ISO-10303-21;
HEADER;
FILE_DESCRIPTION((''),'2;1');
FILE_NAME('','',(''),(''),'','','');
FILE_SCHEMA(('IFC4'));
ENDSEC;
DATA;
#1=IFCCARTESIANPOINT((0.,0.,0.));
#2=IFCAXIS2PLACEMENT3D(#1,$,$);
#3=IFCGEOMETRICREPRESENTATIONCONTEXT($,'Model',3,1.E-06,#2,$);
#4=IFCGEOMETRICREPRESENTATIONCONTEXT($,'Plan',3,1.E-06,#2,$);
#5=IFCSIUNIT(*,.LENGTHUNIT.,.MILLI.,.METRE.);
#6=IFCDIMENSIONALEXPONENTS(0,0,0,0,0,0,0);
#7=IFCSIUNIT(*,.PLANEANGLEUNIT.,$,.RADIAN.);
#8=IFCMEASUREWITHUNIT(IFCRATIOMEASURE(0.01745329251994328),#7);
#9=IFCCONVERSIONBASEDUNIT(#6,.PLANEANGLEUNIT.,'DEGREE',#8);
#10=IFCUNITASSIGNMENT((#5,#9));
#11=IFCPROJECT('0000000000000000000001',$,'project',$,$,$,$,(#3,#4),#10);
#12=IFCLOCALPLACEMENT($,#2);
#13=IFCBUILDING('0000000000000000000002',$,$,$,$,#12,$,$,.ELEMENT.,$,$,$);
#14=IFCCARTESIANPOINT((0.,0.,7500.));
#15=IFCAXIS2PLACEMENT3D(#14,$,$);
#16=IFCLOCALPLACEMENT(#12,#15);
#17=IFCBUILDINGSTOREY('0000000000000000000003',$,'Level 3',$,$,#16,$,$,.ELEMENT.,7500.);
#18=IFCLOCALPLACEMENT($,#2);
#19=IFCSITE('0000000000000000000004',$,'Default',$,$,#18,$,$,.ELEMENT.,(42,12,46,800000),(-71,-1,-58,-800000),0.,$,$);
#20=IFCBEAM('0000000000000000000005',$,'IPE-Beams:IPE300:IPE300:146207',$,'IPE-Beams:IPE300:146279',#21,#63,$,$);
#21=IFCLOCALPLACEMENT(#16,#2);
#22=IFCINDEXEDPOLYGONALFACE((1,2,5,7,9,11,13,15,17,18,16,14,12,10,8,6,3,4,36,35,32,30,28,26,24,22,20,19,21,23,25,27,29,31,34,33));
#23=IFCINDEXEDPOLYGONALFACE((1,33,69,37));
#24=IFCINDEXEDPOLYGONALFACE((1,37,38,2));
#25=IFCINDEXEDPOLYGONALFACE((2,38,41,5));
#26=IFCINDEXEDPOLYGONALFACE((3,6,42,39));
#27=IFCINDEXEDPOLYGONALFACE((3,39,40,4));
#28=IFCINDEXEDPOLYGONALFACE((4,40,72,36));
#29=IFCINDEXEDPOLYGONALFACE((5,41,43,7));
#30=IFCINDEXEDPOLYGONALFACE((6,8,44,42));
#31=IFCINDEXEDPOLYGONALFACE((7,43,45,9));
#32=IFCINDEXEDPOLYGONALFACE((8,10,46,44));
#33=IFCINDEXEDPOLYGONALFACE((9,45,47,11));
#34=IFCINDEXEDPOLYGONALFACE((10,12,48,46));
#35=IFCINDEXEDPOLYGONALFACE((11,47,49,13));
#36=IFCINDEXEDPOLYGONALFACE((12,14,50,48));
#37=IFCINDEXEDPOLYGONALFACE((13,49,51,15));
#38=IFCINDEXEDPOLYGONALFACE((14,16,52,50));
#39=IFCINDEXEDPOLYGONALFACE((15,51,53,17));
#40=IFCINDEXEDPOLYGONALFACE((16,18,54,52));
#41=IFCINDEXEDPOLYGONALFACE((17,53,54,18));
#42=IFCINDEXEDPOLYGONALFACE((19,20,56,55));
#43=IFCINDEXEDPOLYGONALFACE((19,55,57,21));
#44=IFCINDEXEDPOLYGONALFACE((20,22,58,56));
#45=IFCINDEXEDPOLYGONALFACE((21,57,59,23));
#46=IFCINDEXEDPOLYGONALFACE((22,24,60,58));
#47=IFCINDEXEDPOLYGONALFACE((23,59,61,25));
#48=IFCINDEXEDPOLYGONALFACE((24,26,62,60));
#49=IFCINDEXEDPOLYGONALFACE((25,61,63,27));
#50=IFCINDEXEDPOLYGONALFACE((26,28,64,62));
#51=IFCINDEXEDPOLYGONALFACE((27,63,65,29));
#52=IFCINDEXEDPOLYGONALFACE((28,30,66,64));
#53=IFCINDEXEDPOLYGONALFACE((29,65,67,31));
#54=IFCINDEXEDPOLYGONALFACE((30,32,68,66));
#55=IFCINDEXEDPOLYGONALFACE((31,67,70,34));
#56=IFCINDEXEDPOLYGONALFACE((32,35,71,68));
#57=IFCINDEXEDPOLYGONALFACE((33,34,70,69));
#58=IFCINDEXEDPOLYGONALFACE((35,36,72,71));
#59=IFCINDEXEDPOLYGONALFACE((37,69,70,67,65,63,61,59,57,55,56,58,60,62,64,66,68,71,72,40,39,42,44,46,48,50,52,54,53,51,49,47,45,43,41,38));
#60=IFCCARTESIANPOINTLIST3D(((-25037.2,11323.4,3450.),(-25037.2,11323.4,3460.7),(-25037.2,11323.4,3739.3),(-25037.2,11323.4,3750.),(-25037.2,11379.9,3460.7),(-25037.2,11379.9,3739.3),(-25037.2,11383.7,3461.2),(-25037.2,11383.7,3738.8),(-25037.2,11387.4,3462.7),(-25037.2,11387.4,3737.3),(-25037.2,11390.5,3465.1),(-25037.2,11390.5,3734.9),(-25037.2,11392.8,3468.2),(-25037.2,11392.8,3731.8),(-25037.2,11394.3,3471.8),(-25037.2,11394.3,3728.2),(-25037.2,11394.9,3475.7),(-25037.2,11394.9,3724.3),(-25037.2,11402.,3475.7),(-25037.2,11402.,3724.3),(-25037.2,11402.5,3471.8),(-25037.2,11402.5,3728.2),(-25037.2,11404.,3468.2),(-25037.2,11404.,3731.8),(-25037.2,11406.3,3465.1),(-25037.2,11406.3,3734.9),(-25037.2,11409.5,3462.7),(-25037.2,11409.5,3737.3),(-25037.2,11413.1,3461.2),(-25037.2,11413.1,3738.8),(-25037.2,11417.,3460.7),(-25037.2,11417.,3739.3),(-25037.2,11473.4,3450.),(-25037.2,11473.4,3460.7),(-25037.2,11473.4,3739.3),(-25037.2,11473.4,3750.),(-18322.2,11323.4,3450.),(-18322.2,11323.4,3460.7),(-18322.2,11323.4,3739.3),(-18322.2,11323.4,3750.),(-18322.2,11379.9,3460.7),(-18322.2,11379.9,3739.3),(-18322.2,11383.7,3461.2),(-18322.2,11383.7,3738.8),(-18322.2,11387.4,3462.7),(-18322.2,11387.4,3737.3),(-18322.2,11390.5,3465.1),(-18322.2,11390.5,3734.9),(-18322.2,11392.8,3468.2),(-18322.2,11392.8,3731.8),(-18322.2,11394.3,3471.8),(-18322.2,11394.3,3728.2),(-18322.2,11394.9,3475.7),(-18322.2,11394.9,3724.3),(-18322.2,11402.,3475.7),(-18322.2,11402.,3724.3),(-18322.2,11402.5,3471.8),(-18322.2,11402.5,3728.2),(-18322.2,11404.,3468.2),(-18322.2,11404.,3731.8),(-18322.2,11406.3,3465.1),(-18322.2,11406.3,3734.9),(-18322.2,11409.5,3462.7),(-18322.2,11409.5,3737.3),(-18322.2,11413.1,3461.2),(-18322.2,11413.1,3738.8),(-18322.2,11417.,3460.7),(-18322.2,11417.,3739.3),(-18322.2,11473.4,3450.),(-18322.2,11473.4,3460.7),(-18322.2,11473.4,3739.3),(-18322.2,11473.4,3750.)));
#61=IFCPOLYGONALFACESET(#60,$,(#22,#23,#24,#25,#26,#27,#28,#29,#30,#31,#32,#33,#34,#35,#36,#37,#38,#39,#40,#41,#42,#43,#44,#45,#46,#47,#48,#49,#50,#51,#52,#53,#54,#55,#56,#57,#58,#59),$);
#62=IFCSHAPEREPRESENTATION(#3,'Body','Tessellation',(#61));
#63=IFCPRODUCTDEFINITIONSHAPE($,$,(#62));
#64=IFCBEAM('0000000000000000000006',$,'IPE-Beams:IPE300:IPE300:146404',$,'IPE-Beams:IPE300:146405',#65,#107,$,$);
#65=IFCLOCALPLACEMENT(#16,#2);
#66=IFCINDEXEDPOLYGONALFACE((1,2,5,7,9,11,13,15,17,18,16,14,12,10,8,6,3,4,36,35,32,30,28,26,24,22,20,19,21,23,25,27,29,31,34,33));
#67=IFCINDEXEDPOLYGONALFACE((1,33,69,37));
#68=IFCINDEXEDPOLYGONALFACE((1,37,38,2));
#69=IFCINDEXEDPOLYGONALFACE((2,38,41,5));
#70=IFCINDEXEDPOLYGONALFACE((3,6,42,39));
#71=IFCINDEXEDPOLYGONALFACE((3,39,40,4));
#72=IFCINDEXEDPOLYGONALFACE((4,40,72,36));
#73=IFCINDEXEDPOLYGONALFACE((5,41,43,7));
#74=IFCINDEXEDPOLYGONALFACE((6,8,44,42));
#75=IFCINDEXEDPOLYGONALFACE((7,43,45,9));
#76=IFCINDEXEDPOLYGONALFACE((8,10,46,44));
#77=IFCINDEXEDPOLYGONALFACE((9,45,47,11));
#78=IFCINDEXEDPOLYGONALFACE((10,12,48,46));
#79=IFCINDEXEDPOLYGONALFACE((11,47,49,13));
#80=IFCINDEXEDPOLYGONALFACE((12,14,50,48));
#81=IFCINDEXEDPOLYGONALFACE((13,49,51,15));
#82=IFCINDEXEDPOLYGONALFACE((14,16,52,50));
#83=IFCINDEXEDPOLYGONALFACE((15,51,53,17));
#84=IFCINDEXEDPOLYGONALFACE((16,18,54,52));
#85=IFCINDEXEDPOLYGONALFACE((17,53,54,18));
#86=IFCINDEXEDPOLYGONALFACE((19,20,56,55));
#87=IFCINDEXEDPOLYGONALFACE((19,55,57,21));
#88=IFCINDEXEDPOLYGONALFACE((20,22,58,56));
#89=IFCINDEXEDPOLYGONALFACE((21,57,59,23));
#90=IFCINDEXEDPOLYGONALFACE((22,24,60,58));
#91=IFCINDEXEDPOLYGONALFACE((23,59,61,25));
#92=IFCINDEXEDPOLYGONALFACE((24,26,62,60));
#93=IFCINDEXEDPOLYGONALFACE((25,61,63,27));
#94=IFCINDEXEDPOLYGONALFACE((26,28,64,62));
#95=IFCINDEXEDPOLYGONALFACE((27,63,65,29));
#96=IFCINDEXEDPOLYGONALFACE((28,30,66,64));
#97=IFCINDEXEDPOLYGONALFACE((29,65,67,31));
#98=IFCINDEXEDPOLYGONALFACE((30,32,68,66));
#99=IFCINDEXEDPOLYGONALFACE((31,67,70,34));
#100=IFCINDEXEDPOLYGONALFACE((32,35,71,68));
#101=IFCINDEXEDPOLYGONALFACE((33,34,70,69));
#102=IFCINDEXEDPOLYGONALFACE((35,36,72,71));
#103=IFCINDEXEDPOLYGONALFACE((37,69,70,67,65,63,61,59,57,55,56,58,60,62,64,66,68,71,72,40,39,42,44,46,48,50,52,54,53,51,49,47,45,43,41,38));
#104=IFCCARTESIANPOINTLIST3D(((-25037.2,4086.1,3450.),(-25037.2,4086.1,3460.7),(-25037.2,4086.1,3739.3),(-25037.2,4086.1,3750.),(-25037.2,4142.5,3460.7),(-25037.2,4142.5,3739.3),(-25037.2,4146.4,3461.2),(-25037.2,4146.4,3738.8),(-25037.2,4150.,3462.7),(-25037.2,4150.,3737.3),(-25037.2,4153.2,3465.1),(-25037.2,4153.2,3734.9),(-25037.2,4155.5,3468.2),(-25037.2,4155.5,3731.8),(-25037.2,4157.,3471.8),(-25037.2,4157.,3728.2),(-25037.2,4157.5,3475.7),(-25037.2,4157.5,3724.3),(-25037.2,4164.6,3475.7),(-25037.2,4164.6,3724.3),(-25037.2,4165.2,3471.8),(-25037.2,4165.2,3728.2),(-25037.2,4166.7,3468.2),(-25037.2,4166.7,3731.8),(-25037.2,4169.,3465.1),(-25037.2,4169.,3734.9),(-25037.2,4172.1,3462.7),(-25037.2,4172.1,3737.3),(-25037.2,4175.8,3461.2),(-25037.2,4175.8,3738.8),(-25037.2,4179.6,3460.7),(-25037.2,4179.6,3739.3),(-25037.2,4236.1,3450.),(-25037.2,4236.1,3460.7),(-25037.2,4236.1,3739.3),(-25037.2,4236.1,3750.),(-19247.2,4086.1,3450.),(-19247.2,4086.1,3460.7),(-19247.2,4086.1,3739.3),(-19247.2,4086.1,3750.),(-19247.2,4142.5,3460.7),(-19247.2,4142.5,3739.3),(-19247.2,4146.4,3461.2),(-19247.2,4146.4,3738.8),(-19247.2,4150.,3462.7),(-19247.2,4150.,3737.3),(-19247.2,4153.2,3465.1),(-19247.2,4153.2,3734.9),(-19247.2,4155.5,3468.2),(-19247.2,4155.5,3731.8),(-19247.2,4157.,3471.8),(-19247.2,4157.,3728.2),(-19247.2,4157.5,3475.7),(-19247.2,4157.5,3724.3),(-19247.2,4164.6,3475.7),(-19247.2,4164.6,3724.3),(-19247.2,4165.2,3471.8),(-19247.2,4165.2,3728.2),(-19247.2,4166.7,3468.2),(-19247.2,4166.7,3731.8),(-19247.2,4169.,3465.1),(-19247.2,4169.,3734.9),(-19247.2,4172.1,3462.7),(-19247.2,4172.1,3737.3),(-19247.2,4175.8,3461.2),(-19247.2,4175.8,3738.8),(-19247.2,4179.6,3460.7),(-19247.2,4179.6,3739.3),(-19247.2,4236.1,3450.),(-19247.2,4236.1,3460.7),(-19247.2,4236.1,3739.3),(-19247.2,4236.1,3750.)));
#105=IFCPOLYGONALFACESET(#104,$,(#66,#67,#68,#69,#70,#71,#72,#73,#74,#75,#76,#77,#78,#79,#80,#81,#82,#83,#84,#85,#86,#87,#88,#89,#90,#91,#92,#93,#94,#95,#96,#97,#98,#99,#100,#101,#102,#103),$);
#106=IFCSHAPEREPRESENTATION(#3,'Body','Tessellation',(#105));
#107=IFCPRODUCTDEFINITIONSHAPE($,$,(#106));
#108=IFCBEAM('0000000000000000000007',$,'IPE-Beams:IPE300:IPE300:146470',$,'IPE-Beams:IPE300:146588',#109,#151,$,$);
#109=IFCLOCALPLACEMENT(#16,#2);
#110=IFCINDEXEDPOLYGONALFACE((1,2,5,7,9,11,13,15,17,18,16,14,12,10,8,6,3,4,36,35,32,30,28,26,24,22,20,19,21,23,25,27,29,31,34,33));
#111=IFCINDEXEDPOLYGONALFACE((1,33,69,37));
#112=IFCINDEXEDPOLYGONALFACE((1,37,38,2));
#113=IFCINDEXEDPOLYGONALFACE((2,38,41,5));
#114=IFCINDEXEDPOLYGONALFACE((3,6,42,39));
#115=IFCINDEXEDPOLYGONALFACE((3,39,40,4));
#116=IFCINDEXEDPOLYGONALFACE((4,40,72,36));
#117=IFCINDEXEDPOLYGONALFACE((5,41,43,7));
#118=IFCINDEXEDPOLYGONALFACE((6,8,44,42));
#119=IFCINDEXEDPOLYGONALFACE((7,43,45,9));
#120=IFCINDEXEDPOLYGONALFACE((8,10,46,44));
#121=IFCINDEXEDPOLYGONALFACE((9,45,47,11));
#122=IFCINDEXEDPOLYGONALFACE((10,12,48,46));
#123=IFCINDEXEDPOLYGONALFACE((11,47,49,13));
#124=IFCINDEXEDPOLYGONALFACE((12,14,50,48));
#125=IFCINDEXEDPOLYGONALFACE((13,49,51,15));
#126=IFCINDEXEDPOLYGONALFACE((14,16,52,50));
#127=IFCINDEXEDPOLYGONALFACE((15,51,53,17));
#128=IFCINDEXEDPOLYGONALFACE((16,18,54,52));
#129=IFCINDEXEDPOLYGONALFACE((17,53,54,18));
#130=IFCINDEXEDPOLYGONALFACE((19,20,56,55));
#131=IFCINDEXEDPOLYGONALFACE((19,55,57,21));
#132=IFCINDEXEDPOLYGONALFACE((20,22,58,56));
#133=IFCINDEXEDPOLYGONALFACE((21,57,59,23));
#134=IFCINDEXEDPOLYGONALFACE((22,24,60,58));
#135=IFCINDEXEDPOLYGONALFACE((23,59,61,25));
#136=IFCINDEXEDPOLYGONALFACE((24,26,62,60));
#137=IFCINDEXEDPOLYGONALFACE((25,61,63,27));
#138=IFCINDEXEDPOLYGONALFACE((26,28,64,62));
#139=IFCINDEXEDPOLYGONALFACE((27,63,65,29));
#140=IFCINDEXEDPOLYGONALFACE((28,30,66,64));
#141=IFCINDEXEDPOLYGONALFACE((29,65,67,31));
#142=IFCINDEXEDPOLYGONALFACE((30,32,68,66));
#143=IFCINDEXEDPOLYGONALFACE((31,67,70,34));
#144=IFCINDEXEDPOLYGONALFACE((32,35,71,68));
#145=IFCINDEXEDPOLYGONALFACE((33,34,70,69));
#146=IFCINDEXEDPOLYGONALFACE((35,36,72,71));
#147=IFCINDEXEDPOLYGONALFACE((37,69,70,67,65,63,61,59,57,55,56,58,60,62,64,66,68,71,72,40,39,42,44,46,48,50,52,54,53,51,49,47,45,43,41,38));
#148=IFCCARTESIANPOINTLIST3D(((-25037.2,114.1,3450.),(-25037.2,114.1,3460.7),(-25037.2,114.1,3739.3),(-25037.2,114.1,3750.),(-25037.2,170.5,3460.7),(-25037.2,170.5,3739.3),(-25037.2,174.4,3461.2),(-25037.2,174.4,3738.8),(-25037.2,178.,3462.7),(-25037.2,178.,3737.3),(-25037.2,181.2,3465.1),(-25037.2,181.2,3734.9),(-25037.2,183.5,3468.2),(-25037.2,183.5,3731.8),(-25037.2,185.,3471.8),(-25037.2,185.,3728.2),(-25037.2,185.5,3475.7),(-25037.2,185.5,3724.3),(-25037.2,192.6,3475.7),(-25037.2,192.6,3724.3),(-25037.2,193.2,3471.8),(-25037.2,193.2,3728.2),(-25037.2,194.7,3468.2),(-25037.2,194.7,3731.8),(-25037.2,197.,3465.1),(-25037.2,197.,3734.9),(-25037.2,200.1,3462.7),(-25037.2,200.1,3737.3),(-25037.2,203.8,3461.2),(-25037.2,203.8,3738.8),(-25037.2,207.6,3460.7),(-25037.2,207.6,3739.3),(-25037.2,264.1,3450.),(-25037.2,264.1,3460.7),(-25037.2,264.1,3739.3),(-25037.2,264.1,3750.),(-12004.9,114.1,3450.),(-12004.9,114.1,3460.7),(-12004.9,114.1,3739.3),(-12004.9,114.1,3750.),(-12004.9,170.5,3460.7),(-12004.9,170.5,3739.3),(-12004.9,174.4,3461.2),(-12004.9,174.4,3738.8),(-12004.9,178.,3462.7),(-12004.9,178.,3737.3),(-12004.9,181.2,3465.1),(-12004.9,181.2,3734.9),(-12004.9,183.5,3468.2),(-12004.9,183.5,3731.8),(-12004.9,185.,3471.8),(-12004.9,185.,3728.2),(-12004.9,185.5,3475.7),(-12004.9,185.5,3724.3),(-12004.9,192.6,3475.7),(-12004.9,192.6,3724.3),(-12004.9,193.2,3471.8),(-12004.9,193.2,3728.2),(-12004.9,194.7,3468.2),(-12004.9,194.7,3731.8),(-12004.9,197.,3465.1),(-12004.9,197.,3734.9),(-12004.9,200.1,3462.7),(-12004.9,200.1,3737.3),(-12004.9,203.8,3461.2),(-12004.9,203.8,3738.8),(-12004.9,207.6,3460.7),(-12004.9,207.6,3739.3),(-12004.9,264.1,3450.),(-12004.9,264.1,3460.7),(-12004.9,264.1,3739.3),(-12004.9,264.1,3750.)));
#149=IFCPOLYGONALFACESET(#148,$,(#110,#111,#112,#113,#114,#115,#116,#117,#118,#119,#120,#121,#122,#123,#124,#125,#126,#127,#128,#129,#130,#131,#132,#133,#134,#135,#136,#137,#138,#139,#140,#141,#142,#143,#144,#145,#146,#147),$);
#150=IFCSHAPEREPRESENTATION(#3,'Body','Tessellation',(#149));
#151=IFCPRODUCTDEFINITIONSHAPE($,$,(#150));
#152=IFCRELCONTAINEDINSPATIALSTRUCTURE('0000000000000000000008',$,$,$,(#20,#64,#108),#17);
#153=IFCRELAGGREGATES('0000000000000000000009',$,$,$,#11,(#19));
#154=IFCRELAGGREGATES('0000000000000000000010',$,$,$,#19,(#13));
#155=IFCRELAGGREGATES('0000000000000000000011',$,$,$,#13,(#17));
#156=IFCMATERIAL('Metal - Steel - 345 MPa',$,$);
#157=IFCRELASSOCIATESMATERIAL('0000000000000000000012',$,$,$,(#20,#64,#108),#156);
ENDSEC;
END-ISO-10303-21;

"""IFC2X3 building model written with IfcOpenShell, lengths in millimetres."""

from ifc_helpers import new_model, entity, si_unit, converted_unit, frame, frame_2d, origin, place, context, project, spatial, polyline, circle_curve, parameter, trimmed, segment, composite_curve, outline, extrude, material, element, save


model = new_model("IFC2X3")

# Units and contexts
model_context = context("Model", 3, precision=1e-06, world=origin())
plan_context = context("Plan", 3, precision=1e-06, world=origin())
ifc_project = project(units=[si_unit("LENGTHUNIT", "METRE", prefix="MILLI"), converted_unit("PLANEANGLEUNIT", "DEGREE", entity("IfcRatioMeasure", 0.01745329251994328), si_unit("PLANEANGLEUNIT", "RADIAN"), dimensions=[0, 0, 0, 0, 0, 0, 0])], contexts=[model_context, plan_context])

# Site, building, storey
site_placement = place(None, origin())
site = spatial("IfcSite", under=ifc_project, at=site_placement, Name="Default", CompositionType="ELEMENT", RefLatitude=(42, 12, 46, 800000), RefLongitude=(-71, -1, -58, -800000), RefElevation=0.0)
building_placement = place(None, origin())
building = spatial("IfcBuilding", under=site, at=building_placement, CompositionType="ELEMENT")
storey_placement = place(building_placement, frame((0.0, 0.0, 7500.0)))
storey = spatial("IfcBuildingStorey", under=building, at=storey_placement, Name="Level 3", CompositionType="ELEMENT", Elevation=7500.0)

# Shared definitions
ifc_material_1 = material(Name="Metal - Steel - 345 MPa")

# Beams
beam_1_placement = place(storey_placement, frame((-25022.4, 11398.4, 3750.0), z_axis=(0.0, 0.0, 1.0), x_axis=(0.0, -1.0, 0.0)))
element("IfcBeam", 1, at=beam_1_placement, inside=storey, material=ifc_material_1, Name="IPE-Beams:IPE300:IPE300:146207", ObjectType="IPE-Beams:IPE300:146279", context=model_context, shape_type="SweptSolid", body=[
    extrude(outline(composite_curve([segment(polyline([(-75.0, -139.3), (-75.0, -150.0)]), True, "CONTINUOUS"), segment(polyline([(-75.0, -150.0), (75.0, -150.0)]), True, "CONTINUOUS"), segment(polyline([(75.0, -150.0), (75.0, -139.3)]), True, "CONTINUOUS"), segment(polyline([(75.0, -139.3), (18.5, -139.3)]), True, "CONTINUOUS"), segment(trimmed(circle_curve(frame_2d((18.5, -124.3), x_axis=(1.0, 0.0)), 15.0), [parameter(180.0)], [parameter(270.0)], True, "PARAMETER"), False, "CONTINUOUS"), segment(polyline([(3.5, -124.3), (3.5, 124.3)]), True, "CONTINUOUS"), segment(trimmed(circle_curve(frame_2d((18.5, 124.3), x_axis=(1.0, 0.0)), 15.0), [parameter(90.0)], [parameter(180.0)], True, "PARAMETER"), False, "CONTINUOUS"), segment(polyline([(18.5, 139.3), (75.0, 139.3)]), True, "CONTINUOUS"), segment(polyline([(75.0, 139.3), (75.0, 150.0)]), True, "CONTINUOUS"), segment(polyline([(75.0, 150.0), (-75.0, 150.0)]), True, "CONTINUOUS"), segment(polyline([(-75.0, 150.0), (-75.0, 139.3)]), True, "CONTINUOUS"), segment(polyline([(-75.0, 139.3), (-18.6, 139.3)]), True, "CONTINUOUS"), segment(trimmed(circle_curve(frame_2d((-18.6, 124.3), x_axis=(1.0, 0.0)), 15.0), [parameter(360.0)], [parameter(90.0)], True, "PARAMETER"), False, "CONTINUOUS"), segment(polyline([(-3.6, 124.3), (-3.6, -124.3)]), True, "CONTINUOUS"), segment(trimmed(circle_curve(frame_2d((-18.6, -124.3), x_axis=(1.0, 0.0)), 15.0), [parameter(270.0)], [parameter(0.0)], True, "PARAMETER"), False, "CONTINUOUS"), segment(polyline([(-18.6, -139.3), (-75.0, -139.3)]), True, "CONTINUOUS")], self_intersect=False)), frame((0.0, -14.8, -150.0), z_axis=(0.0, -1.0, 0.0), x_axis=(1.0, 0.0, 0.0)), (0.0, 0.0, -1.0), 6715.0),
])
beam_2_placement = place(storey_placement, frame((-25037.2, 4161.1, 3750.0), z_axis=(0.0, 0.0, 1.0), x_axis=(0.0, -1.0, 0.0)))
element("IfcBeam", 2, at=beam_2_placement, inside=storey, material=ifc_material_1, Name="IPE-Beams:IPE300:IPE300:146404", ObjectType="IPE-Beams:IPE300:146405", context=model_context, shape_type="SweptSolid", body=[
    extrude(outline(composite_curve([segment(polyline([(-75.0, -139.3), (-75.0, -150.0)]), True, "CONTINUOUS"), segment(polyline([(-75.0, -150.0), (75.0, -150.0)]), True, "CONTINUOUS"), segment(polyline([(75.0, -150.0), (75.0, -139.3)]), True, "CONTINUOUS"), segment(polyline([(75.0, -139.3), (18.6, -139.3)]), True, "CONTINUOUS"), segment(trimmed(circle_curve(frame_2d((18.6, -124.3), x_axis=(0.0, -1.0)), 15.0), [parameter(270.0)], [parameter(360.0)], True, "PARAMETER"), False, "CONTINUOUS"), segment(polyline([(3.6, -124.3), (3.6, 124.3)]), True, "CONTINUOUS"), segment(trimmed(circle_curve(frame_2d((18.6, 124.3), x_axis=(-1.0, 0.0)), 15.0), [parameter(270.0)], [parameter(0.0)], True, "PARAMETER"), False, "CONTINUOUS"), segment(polyline([(18.6, 139.3), (75.0, 139.3)]), True, "CONTINUOUS"), segment(polyline([(75.0, 139.3), (75.0, 150.0)]), True, "CONTINUOUS"), segment(polyline([(75.0, 150.0), (-75.0, 150.0)]), True, "CONTINUOUS"), segment(polyline([(-75.0, 150.0), (-75.0, 139.3)]), True, "CONTINUOUS"), segment(polyline([(-75.0, 139.3), (-18.5, 139.3)]), True, "CONTINUOUS"), segment(trimmed(circle_curve(frame_2d((-18.5, 124.3), x_axis=(0.0, 1.0)), 15.0), [parameter(270.0)], [parameter(0.0)], True, "PARAMETER"), False, "CONTINUOUS"), segment(polyline([(-3.5, 124.3), (-3.5, -124.3)]), True, "CONTINUOUS"), segment(trimmed(circle_curve(frame_2d((-18.5, -124.3), x_axis=(1.0, 0.0)), 15.0), [parameter(270.0)], [parameter(0.0)], True, "PARAMETER"), False, "CONTINUOUS"), segment(polyline([(-18.5, -139.3), (-75.0, -139.3)]), True, "CONTINUOUS")], self_intersect=False)), frame((0.0, 0.0, -150.0), z_axis=(0.0, -1.0, 0.0), x_axis=(1.0, 0.0, 0.0)), (0.0, 0.0, -1.0), 5790.0),
])
beam_3_placement = place(storey_placement, frame((-25047.2, 189.1, 3750.0), z_axis=(0.0, 0.0, 1.0), x_axis=(0.0, -1.0, 0.0)))
element("IfcBeam", 3, at=beam_3_placement, inside=storey, material=ifc_material_1, Name="IPE-Beams:IPE300:IPE300:146470", ObjectType="IPE-Beams:IPE300:146588", context=model_context, shape_type="SweptSolid", body=[
    extrude(outline(composite_curve([segment(polyline([(-75.0, -139.3), (-75.0, -150.0)]), True, "CONTINUOUS"), segment(polyline([(-75.0, -150.0), (75.0, -150.0)]), True, "CONTINUOUS"), segment(polyline([(75.0, -150.0), (75.0, -139.3)]), True, "CONTINUOUS"), segment(polyline([(75.0, -139.3), (18.5, -139.3)]), True, "CONTINUOUS"), segment(trimmed(circle_curve(frame_2d((18.5, -124.3), x_axis=(1.0, 0.0)), 15.0), [parameter(180.0)], [parameter(270.0)], True, "PARAMETER"), False, "CONTINUOUS"), segment(polyline([(3.5, -124.3), (3.5, 124.3)]), True, "CONTINUOUS"), segment(trimmed(circle_curve(frame_2d((18.5, 124.3), x_axis=(1.0, 0.0)), 15.0), [parameter(90.0)], [parameter(180.0)], True, "PARAMETER"), False, "CONTINUOUS"), segment(polyline([(18.5, 139.3), (75.0, 139.3)]), True, "CONTINUOUS"), segment(polyline([(75.0, 139.3), (75.0, 150.0)]), True, "CONTINUOUS"), segment(polyline([(75.0, 150.0), (-75.0, 150.0)]), True, "CONTINUOUS"), segment(polyline([(-75.0, 150.0), (-75.0, 139.3)]), True, "CONTINUOUS"), segment(polyline([(-75.0, 139.3), (-18.6, 139.3)]), True, "CONTINUOUS"), segment(trimmed(circle_curve(frame_2d((-18.6, 124.3), x_axis=(1.0, 0.0)), 15.0), [parameter(360.0)], [parameter(90.0)], True, "PARAMETER"), False, "CONTINUOUS"), segment(polyline([(-3.6, 124.3), (-3.6, -124.3)]), True, "CONTINUOUS"), segment(trimmed(circle_curve(frame_2d((-18.6, -124.3), x_axis=(1.0, 0.0)), 15.0), [parameter(270.0)], [parameter(0.0)], True, "PARAMETER"), False, "CONTINUOUS"), segment(polyline([(-18.6, -139.3), (-75.0, -139.3)]), True, "CONTINUOUS")], self_intersect=False)), frame((0.0, 10.0, -150.0), z_axis=(0.0, -1.0, 0.0), x_axis=(1.0, 0.0, 0.0)), (0.0, 0.0, -1.0), 13032.3),
])

save(model, "model.ifc")
